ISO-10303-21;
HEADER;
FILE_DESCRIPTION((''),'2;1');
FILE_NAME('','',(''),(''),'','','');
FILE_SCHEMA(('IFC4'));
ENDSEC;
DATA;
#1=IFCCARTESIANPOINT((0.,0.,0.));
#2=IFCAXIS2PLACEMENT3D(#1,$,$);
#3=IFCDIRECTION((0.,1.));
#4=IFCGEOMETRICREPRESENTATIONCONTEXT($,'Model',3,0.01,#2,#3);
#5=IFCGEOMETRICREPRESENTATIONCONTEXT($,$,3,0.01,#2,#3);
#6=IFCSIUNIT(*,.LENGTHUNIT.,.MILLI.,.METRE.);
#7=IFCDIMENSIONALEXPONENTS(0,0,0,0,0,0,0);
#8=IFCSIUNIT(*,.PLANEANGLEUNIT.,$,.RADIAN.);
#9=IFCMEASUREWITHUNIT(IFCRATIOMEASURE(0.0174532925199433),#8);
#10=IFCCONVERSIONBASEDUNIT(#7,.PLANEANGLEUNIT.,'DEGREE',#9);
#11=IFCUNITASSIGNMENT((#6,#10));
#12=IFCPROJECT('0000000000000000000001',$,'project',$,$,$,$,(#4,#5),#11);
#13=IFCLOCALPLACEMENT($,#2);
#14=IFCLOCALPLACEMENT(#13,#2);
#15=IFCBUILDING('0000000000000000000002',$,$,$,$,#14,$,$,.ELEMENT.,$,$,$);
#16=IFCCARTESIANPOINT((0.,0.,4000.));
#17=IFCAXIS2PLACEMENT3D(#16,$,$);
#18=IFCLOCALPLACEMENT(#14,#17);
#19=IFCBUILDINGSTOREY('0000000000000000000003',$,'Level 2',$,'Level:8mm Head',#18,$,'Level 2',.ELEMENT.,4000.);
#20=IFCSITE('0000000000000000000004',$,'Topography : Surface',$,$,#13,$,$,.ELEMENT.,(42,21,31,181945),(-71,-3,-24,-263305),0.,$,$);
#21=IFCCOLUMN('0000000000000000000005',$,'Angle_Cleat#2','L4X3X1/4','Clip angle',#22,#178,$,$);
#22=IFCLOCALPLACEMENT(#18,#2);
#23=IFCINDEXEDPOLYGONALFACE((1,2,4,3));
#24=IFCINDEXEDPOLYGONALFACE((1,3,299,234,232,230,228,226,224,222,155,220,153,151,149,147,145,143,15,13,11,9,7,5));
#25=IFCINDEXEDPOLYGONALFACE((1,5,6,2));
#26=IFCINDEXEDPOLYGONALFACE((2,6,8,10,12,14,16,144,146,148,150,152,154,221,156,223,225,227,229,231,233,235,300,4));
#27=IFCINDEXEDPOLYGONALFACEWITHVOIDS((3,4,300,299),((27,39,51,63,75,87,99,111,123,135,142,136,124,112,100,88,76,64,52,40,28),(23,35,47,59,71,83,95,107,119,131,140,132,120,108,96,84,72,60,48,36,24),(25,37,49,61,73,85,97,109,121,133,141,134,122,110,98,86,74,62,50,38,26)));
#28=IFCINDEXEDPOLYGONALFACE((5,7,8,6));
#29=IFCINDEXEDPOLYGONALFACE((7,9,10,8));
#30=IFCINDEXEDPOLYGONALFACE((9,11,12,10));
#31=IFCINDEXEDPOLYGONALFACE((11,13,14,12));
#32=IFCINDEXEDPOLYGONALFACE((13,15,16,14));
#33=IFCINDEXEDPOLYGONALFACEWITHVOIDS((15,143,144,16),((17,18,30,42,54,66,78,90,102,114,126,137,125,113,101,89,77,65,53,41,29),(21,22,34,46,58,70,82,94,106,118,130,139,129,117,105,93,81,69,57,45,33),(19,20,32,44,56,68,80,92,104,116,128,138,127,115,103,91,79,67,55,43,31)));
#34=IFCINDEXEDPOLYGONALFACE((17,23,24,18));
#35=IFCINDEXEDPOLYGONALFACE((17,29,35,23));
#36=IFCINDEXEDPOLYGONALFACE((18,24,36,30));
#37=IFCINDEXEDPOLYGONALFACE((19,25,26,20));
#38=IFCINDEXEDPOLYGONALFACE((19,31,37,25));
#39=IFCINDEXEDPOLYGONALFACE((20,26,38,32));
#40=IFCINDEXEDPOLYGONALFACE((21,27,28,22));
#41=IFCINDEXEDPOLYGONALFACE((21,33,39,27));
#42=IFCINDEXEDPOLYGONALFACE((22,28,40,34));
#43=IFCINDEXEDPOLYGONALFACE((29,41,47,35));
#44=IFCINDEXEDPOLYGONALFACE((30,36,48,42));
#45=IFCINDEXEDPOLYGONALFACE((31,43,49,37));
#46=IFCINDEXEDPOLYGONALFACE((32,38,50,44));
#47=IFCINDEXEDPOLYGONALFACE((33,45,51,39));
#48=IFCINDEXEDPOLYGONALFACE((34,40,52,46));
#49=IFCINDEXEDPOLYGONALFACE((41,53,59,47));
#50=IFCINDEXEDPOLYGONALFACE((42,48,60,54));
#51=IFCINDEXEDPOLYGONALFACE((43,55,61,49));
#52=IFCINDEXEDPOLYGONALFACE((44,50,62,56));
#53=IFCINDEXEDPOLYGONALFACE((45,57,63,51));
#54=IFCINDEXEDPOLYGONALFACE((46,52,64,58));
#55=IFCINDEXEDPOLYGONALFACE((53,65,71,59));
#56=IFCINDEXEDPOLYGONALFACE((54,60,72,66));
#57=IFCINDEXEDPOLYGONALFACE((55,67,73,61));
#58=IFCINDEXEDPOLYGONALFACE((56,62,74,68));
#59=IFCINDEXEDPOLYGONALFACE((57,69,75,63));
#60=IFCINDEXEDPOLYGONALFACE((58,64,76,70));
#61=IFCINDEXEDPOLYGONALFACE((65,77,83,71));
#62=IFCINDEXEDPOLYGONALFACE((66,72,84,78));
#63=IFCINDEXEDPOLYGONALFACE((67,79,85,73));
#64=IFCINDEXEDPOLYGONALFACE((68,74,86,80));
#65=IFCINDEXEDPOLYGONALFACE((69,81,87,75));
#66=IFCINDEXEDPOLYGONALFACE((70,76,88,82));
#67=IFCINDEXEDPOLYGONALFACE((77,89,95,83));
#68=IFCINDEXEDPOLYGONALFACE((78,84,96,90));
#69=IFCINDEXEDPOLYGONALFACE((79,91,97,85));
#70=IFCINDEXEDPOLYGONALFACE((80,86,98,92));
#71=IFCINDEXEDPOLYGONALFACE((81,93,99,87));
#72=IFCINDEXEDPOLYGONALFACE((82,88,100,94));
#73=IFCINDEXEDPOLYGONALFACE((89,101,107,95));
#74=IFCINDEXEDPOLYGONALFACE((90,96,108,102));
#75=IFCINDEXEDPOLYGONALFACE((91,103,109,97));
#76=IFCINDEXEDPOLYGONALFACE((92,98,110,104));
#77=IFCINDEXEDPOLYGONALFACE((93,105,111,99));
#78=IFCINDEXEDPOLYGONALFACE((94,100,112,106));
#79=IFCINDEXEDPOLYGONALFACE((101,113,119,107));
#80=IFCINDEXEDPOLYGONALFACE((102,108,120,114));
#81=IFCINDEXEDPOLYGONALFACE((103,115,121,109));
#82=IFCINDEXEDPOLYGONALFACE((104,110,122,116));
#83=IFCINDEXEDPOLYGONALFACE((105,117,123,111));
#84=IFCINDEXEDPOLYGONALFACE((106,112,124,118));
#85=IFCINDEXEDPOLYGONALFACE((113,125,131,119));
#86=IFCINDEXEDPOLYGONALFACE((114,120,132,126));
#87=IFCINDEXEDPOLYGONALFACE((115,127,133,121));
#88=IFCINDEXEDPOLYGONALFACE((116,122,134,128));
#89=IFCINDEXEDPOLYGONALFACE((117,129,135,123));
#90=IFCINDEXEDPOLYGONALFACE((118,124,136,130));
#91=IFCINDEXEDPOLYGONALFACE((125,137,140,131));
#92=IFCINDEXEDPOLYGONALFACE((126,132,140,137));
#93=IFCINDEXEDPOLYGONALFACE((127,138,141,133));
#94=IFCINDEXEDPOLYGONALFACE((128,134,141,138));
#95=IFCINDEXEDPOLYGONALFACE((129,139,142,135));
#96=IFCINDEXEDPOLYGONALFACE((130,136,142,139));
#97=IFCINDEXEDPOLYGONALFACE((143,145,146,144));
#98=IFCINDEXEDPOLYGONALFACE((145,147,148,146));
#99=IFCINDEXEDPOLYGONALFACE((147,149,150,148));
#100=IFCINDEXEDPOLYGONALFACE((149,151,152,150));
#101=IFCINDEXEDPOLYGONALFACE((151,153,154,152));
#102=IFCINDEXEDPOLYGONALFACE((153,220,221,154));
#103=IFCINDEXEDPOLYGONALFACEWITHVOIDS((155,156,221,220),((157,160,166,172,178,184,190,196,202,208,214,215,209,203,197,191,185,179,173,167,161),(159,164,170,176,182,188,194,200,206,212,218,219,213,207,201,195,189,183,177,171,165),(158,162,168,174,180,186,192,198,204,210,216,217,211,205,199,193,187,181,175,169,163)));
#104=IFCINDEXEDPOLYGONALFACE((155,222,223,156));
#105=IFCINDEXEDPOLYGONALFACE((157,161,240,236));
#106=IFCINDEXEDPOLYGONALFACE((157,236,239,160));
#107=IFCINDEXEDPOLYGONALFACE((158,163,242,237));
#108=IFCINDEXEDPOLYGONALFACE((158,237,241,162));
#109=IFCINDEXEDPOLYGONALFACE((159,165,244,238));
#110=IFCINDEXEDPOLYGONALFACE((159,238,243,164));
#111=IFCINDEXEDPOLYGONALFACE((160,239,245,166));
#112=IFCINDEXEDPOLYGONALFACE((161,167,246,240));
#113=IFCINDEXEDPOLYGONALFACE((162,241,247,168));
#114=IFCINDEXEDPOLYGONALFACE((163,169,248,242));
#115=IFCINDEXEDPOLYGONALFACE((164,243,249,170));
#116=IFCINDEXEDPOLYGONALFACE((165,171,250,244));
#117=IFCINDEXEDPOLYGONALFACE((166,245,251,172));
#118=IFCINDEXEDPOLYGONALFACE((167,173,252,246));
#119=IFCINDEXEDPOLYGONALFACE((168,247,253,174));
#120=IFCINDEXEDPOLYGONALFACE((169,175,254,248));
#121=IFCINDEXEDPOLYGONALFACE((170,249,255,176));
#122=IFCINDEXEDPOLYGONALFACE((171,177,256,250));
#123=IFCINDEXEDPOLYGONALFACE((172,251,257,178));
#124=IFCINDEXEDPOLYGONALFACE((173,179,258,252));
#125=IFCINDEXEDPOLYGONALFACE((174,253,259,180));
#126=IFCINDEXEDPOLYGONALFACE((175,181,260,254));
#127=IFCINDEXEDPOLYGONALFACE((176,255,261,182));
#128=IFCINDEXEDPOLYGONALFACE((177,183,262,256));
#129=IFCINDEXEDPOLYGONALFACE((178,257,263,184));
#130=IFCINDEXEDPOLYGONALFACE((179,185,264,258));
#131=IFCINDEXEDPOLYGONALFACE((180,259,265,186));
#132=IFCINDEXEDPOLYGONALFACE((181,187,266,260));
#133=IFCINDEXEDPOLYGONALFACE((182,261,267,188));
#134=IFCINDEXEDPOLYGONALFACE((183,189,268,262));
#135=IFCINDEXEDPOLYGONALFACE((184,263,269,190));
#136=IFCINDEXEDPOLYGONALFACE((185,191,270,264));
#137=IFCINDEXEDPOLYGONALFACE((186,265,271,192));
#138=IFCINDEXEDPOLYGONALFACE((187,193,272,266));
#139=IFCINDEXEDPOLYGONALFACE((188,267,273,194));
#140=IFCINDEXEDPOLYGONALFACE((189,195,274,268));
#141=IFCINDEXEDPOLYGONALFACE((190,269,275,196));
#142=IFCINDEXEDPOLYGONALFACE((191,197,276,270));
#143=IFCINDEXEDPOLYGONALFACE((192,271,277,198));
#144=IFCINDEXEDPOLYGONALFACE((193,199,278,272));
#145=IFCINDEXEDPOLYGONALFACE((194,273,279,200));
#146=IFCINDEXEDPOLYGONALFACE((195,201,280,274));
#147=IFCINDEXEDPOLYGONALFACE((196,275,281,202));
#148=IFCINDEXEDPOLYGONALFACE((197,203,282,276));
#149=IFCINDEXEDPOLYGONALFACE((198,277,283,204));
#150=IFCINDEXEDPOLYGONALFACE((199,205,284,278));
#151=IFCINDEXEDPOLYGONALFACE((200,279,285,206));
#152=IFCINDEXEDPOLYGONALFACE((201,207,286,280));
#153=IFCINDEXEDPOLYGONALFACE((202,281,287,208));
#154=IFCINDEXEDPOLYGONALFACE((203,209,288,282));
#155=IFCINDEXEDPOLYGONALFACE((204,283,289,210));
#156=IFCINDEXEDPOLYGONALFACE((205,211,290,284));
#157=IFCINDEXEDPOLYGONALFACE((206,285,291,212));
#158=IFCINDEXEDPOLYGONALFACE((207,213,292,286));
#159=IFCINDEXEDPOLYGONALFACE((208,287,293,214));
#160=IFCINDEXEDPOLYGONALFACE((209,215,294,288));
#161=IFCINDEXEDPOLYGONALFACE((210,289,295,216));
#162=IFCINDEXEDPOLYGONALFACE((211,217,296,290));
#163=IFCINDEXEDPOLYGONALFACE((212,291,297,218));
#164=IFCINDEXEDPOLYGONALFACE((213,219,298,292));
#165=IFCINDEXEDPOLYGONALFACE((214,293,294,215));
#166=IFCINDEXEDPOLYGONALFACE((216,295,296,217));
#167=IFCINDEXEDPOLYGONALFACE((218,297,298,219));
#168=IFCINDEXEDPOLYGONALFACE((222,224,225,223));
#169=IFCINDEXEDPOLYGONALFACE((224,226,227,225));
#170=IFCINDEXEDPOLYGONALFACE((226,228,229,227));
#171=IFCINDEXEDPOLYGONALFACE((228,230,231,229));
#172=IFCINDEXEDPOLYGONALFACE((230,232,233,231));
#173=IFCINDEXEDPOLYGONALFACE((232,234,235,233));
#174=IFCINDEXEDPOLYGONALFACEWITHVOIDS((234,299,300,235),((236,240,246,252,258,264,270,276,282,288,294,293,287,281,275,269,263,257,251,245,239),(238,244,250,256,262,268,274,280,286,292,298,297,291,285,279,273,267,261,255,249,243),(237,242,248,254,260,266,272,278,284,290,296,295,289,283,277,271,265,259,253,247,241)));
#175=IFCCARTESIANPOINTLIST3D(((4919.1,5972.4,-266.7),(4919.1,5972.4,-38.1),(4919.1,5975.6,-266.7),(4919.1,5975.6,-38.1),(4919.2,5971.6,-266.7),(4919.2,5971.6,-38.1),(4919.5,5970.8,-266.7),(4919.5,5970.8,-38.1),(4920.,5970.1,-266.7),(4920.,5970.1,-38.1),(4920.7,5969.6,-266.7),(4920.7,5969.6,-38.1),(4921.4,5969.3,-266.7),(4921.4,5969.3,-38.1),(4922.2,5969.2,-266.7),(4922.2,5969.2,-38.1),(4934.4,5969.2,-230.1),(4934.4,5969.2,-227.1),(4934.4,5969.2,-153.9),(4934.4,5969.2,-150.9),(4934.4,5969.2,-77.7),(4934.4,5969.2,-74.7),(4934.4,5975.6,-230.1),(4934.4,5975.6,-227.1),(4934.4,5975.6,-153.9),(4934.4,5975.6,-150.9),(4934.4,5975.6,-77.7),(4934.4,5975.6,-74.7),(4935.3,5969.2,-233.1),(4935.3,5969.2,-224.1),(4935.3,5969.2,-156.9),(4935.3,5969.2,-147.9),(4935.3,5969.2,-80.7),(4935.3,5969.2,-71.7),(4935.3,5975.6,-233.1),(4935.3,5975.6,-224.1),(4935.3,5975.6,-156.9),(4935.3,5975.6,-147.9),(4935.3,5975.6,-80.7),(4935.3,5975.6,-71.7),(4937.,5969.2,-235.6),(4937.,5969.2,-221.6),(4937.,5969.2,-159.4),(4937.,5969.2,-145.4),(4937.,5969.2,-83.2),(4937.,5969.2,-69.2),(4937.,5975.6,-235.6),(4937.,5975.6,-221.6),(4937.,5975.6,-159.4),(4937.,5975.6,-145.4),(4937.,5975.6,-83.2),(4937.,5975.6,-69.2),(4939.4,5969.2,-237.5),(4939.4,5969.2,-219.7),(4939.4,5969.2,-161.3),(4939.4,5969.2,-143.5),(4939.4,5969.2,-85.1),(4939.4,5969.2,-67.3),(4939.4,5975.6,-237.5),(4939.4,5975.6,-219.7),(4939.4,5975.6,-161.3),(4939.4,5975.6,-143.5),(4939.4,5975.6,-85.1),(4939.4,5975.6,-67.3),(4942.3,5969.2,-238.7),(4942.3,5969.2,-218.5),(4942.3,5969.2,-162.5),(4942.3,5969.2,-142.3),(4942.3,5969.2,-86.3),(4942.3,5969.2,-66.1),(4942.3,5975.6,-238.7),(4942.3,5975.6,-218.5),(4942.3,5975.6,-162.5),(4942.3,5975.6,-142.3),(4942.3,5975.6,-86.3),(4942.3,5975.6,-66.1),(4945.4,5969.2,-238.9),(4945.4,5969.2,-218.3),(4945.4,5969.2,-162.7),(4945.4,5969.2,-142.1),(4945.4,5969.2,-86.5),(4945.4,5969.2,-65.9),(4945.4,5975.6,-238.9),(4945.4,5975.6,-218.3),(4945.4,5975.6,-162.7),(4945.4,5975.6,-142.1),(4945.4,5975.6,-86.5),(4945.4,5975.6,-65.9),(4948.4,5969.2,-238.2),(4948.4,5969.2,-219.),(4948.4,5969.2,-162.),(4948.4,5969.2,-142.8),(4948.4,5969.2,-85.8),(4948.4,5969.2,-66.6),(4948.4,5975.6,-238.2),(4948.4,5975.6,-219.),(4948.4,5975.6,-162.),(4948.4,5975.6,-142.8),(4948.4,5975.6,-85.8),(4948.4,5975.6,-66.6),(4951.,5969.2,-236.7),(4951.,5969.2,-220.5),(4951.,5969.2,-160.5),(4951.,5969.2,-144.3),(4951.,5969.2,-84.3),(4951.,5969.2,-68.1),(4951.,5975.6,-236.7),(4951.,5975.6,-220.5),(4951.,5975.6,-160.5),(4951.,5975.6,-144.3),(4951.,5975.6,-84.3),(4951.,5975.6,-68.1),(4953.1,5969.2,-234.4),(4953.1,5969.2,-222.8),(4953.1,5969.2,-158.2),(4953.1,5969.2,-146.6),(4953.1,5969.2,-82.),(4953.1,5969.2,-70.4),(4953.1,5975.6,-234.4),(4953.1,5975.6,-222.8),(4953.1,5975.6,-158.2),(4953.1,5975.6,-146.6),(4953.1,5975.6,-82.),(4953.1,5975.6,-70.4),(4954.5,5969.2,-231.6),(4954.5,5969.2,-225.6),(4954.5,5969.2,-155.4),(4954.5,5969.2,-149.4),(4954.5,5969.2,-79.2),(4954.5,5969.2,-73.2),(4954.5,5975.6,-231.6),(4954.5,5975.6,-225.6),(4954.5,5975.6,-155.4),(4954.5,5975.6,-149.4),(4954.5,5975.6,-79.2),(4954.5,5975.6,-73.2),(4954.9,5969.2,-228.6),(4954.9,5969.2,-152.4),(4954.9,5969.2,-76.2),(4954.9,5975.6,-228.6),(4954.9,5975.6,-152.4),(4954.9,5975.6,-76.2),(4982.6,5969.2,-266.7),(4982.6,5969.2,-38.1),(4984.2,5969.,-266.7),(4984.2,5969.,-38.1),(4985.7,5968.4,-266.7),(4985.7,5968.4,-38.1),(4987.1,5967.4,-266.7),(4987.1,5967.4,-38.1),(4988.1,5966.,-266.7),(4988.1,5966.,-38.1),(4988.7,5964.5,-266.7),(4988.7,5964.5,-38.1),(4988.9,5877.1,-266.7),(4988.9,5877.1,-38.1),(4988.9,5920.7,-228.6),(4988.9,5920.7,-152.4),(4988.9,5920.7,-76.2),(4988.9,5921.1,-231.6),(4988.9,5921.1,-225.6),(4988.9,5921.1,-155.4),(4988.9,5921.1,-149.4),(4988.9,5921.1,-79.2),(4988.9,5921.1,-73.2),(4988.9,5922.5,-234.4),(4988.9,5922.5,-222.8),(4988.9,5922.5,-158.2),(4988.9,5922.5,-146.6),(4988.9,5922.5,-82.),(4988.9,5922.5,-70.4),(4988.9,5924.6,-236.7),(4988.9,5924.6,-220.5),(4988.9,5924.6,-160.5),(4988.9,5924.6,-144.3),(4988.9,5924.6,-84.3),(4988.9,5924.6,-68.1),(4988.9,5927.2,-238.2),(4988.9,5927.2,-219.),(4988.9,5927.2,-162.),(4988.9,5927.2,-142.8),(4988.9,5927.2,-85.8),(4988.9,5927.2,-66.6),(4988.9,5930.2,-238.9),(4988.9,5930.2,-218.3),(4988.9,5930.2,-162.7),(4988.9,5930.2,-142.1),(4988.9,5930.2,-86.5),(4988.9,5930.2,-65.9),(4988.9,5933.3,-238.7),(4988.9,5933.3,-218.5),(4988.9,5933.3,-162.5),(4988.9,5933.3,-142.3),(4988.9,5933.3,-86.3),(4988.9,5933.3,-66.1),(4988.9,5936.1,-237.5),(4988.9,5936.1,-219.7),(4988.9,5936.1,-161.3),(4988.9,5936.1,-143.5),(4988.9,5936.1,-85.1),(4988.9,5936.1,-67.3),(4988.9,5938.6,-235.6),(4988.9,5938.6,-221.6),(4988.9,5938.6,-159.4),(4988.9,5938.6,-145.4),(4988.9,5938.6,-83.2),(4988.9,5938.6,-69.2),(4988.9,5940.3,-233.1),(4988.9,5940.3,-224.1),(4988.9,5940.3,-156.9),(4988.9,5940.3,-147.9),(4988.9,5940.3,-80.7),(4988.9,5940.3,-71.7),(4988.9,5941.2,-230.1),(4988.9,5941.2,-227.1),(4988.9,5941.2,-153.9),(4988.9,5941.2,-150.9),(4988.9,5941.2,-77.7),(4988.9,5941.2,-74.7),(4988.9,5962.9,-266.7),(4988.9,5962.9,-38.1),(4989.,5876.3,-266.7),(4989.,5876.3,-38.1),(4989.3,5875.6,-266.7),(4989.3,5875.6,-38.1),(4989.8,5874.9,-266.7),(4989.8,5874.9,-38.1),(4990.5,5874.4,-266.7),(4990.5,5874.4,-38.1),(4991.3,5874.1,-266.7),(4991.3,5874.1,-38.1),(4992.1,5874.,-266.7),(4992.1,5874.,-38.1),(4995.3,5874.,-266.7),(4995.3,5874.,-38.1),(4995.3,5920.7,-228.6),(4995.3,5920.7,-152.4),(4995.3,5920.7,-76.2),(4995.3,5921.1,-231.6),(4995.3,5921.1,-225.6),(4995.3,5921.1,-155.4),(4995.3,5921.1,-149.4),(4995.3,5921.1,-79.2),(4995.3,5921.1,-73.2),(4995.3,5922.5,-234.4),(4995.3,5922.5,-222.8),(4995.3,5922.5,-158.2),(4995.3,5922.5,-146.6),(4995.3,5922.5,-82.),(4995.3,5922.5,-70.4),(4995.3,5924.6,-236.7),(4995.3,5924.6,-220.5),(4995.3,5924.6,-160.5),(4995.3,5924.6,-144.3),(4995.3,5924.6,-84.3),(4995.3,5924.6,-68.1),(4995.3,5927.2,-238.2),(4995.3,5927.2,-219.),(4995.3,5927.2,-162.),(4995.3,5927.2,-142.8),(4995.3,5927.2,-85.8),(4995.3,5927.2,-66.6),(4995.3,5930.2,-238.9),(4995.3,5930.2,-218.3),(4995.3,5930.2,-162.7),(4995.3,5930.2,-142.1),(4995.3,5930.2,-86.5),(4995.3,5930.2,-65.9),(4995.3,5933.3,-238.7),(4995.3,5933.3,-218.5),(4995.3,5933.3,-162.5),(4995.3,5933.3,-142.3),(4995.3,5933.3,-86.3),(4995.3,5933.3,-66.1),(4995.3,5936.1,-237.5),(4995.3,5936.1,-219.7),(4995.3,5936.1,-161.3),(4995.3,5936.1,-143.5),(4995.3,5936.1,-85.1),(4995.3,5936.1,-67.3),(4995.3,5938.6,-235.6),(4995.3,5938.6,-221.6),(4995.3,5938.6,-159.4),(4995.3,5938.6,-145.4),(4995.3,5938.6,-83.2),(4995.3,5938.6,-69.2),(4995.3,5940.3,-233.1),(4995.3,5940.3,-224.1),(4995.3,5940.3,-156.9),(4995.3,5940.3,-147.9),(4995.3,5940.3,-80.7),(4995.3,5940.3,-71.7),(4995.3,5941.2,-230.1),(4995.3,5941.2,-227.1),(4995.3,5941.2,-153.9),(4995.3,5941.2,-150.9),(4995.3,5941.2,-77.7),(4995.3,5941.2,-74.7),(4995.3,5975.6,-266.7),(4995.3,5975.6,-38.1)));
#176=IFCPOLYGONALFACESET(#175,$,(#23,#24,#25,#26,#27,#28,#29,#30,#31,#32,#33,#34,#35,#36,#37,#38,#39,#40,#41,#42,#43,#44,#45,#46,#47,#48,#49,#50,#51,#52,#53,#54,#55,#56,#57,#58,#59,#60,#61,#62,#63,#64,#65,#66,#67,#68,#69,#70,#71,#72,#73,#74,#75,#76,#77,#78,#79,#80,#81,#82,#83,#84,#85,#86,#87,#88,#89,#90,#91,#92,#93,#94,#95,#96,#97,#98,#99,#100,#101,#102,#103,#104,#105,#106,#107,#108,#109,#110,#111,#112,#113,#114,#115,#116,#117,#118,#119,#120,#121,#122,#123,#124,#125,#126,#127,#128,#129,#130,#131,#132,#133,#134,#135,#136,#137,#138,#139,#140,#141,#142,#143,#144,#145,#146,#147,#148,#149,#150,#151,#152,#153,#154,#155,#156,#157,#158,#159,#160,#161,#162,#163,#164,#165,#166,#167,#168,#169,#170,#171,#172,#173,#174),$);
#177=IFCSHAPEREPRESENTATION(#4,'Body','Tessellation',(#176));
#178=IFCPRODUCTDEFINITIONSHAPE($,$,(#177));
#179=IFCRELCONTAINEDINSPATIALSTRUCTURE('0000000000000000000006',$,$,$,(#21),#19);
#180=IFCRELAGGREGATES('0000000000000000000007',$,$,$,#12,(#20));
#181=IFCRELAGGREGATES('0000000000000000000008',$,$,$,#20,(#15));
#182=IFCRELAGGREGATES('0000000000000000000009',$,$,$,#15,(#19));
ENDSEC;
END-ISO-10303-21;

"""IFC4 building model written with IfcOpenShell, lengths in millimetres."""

from ifc_helpers import new_model, entity, si_unit, converted_unit, direction, frame, frame_2d, origin, origin_2d_with_axis, place, context, project, spatial, circle, l_section, extrude, element, save


model = new_model("IFC4")

# Units and contexts
model_context = context("Model", 3, precision=0.01, world=origin(), true_north=direction((0.0, 1.0)))
context_of_model = context(None, 3, precision=0.01, world=origin(), true_north=direction((0.0, 1.0)))
ifc_project = project(units=[si_unit("LENGTHUNIT", "METRE", prefix="MILLI"), converted_unit("PLANEANGLEUNIT", "DEGREE", entity("IfcRatioMeasure", 0.0174532925199433), si_unit("PLANEANGLEUNIT", "RADIAN"), dimensions=[0, 0, 0, 0, 0, 0, 0])], contexts=[model_context, context_of_model])

# Site, building, storey
site_placement = place(None, origin())
site = spatial("IfcSite", under=ifc_project, at=site_placement, Name="Topography : Surface", CompositionType="ELEMENT", RefLatitude=(42, 21, 31, 181945), RefLongitude=(-71, -3, -24, -263305), RefElevation=0.0)
building_placement = place(site_placement, origin())
building = spatial("IfcBuilding", under=site, at=building_placement, CompositionType="ELEMENT")
storey_placement = place(building_placement, frame((0.0, 0.0, 4000.0)))
storey = spatial("IfcBuildingStorey", under=building, at=storey_placement, Name="Level 2", ObjectType="Level:8mm Head", LongName="Level 2", CompositionType="ELEMENT", Elevation=4000.0)

# Column, openings
column_1_placement = place(storey_placement, frame((4977.0, 5944.4, -38.1), z_axis=(0.0, 0.0, 1.0), x_axis=(-1.0, 0.0, 0.0)))
column_1 = element("IfcColumn", 1, at=column_1_placement, inside=storey, Name="Angle_Cleat#2", Description="L4X3X1/4", ObjectType="Clip angle", context=model_context, shape_type="SweptSolid", body=[
    extrude(l_section(Depth=101.6, Width=76.2, Thickness=6.3, FilletRadius=6.3, EdgeRadius=3.2, at=frame_2d((19.8, 19.7))), origin(), (0.0, 0.0, -1.0), 228.6),
])
opening_1_placement = place(column_1_placement, frame((-11.6, 13.5, -114.3), z_axis=(-1.0, 0.0, 0.0), x_axis=(0.0, 1.0, 0.0)))
element("IfcOpeningElement", 2, at=opening_1_placement, cuts=column_1, ObjectType="Opening", context=model_context, shape_type="SweptSolid", body=[
    extrude(circle(Radius=10.3, at=origin_2d_with_axis()), origin(), (0.0, 0.0, 1.0), 7.3),
])
opening_2_placement = place(column_1_placement, frame((-11.6, 13.5, -114.3), z_axis=(-1.0, 0.0, 0.0), x_axis=(0.0, 1.0, 0.0)))
element("IfcOpeningElement", 3, at=opening_2_placement, cuts=column_1, ObjectType="Opening", context=model_context, shape_type="SweptSolid", body=[
    extrude(circle(Radius=10.3, at=frame_2d((0.0, 76.2), x_axis=(1.0, 0.0))), origin(), (0.0, 0.0, 1.0), 7.3),
])
opening_3_placement = place(column_1_placement, frame((-11.6, 13.5, -114.3), z_axis=(-1.0, 0.0, 0.0), x_axis=(0.0, 1.0, 0.0)))
element("IfcOpeningElement", 4, at=opening_3_placement, cuts=column_1, ObjectType="Opening", context=model_context, shape_type="SweptSolid", body=[
    extrude(circle(Radius=10.3, at=frame_2d((0.0, -76.2), x_axis=(1.0, 0.0))), origin(), (0.0, 0.0, 1.0), 7.3),
])
opening_4_placement = place(column_1_placement, frame((32.4, -31.5, -114.3), z_axis=(0.0, 1.0, 0.0), x_axis=(-1.0, 0.0, 0.0)))
element("IfcOpeningElement", 5, at=opening_4_placement, cuts=column_1, ObjectType="Opening", context=model_context, shape_type="SweptSolid", body=[
    extrude(circle(Radius=10.3, at=origin_2d_with_axis()), origin(), (0.0, 0.0, 1.0), 7.3),
])
opening_5_placement = place(column_1_placement, frame((32.4, -31.5, -114.3), z_axis=(0.0, 1.0, 0.0), x_axis=(-1.0, 0.0, 0.0)))
element("IfcOpeningElement", 6, at=opening_5_placement, cuts=column_1, ObjectType="Opening", context=model_context, shape_type="SweptSolid", body=[
    extrude(circle(Radius=10.3, at=frame_2d((0.0, 76.2), x_axis=(1.0, 0.0))), origin(), (0.0, 0.0, 1.0), 7.3),
])
opening_6_placement = place(column_1_placement, frame((32.4, -31.5, -114.3), z_axis=(0.0, 1.0, 0.0), x_axis=(-1.0, 0.0, 0.0)))
element("IfcOpeningElement", 7, at=opening_6_placement, cuts=column_1, ObjectType="Opening", context=model_context, shape_type="SweptSolid", body=[
    extrude(circle(Radius=10.3, at=frame_2d((0.0, -76.2), x_axis=(1.0, 0.0))), origin(), (0.0, 0.0, 1.0), 7.3),
])

save(model, "model.ifc")
